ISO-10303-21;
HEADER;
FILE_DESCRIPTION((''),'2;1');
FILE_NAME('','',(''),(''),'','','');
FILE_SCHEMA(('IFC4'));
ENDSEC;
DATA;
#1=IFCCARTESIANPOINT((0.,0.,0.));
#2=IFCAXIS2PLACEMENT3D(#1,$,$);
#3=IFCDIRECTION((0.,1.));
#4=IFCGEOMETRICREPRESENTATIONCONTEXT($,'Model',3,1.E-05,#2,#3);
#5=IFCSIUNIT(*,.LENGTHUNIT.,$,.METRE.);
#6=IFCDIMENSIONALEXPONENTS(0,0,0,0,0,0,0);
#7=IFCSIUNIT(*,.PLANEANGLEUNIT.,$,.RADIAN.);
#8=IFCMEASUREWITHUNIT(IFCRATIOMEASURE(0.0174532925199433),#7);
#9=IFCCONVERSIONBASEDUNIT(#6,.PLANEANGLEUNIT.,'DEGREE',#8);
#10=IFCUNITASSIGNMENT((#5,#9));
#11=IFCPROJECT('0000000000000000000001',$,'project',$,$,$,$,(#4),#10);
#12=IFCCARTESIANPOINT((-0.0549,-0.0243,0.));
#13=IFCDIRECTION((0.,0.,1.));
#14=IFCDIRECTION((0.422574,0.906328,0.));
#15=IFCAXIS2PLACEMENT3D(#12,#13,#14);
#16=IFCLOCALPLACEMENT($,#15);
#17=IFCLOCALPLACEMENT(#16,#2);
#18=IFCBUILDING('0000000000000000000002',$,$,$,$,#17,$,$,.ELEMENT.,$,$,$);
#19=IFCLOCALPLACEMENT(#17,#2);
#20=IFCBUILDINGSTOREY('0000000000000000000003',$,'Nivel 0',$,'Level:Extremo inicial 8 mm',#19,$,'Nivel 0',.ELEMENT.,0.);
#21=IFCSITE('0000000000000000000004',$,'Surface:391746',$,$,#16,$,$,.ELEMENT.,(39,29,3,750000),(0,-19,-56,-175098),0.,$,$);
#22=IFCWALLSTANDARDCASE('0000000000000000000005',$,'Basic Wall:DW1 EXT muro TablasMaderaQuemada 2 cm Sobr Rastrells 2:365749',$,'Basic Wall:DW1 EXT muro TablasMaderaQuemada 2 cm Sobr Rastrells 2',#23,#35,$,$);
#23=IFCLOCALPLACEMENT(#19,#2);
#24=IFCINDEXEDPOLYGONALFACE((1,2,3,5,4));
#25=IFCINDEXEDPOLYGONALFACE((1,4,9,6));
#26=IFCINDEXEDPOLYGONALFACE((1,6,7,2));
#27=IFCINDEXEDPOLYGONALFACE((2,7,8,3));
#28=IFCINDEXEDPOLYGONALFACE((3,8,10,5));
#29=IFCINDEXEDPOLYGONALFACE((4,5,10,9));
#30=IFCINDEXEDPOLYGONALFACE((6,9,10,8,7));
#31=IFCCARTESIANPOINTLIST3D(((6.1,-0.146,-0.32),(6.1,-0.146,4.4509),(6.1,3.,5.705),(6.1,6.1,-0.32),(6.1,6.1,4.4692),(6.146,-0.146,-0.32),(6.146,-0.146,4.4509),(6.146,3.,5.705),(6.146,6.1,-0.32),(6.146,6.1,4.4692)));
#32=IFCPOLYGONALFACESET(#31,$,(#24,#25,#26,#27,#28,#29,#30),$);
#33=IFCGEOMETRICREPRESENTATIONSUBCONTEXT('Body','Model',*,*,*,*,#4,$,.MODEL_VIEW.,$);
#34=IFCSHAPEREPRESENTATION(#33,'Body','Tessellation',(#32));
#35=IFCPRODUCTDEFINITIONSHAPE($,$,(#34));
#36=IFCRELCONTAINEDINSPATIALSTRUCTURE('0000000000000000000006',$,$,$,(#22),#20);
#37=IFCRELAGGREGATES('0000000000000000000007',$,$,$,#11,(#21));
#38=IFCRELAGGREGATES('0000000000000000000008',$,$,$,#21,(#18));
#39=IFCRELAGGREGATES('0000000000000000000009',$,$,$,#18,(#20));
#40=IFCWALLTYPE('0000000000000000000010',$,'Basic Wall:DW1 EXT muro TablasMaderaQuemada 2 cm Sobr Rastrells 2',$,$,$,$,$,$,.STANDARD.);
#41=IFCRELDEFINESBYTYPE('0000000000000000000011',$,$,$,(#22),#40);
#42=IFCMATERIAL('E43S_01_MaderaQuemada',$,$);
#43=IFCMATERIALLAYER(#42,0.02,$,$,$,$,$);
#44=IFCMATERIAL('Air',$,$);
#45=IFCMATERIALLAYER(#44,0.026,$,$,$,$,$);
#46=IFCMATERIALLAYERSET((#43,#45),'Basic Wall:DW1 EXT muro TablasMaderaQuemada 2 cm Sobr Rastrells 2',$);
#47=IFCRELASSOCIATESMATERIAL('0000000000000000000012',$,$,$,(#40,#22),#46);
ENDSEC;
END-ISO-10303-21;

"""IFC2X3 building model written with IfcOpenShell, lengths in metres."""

from ifc_helpers import new_model, entity, si_unit, converted_unit, direction, frame, frame_2d, origin, place, context, subcontext, project, spatial, polyline, rectangle, extrude, clip, bounded_halfspace, material, layer, layer_set, layer_usage, type_object, element, save


model = new_model("IFC2X3")

# Units and contexts
model_context = context("Model", 3, precision=1e-05, world=origin(), true_north=direction((0.0, 1.0)))
body_context = subcontext(model_context, "Body", "Model", "MODEL_VIEW")
ifc_project = project(units=[si_unit("LENGTHUNIT", "METRE"), converted_unit("PLANEANGLEUNIT", "DEGREE", entity("IfcRatioMeasure", 0.0174532925199433), si_unit("PLANEANGLEUNIT", "RADIAN"), dimensions=[0, 0, 0, 0, 0, 0, 0])], contexts=[model_context])

# Site, building, storey
site_placement = place(None, frame((-0.0549, -0.0243, 0.0), z_axis=(0.0, 0.0, 1.0), x_axis=(0.422574, 0.906328, 0.0)))
site = spatial("IfcSite", under=ifc_project, at=site_placement, Name="Surface:391746", CompositionType="ELEMENT", RefLatitude=(39, 29, 3, 750000), RefLongitude=(0, -19, -56, -175098), RefElevation=0.0)
building_placement = place(site_placement, origin())
building = spatial("IfcBuilding", under=site, at=building_placement, CompositionType="ELEMENT")
storey_placement = place(building_placement, origin())
storey = spatial("IfcBuildingStorey", under=building, at=storey_placement, Name="Nivel 0", ObjectType="Level:Extremo inicial 8 mm", LongName="Nivel 0", CompositionType="ELEMENT", Elevation=0.0)

# Wall
ifc_material_1 = material(Name="E43S_01_MaderaQuemada")
ifc_layer_1 = layer(ifc_material_1, 0.02)
ifc_material_2 = material(Name="Air")
ifc_layer_2 = layer(ifc_material_2, 0.026)
ifc_layer_set_1 = layer_set([ifc_layer_1, ifc_layer_2], Name="Basic Wall:DW1 EXT muro TablasMaderaQuemada 2 cm Sobr Rastrells 2")
ifc_layer_usage_1 = layer_usage(ifc_layer_set_1, "AXIS2", "NEGATIVE", 0.023)
wall_type_1 = type_object("IfcWallType", Name="Basic Wall:DW1 EXT muro TablasMaderaQuemada 2 cm Sobr Rastrells 2", PredefinedType="STANDARD", material=ifc_layer_set_1)
wall_1_placement = place(storey_placement, frame((6.123, 6.1, -0.32), z_axis=(0.0, 0.0, 1.0), x_axis=(0.0, -1.0, 0.0)))
element("IfcWallStandardCase", 1, at=wall_1_placement, inside=storey, type_object=wall_type_1, material=ifc_layer_usage_1, Name="Basic Wall:DW1 EXT muro TablasMaderaQuemada 2 cm Sobr Rastrells 2:365749", ObjectType="Basic Wall:DW1 EXT muro TablasMaderaQuemada 2 cm Sobr Rastrells 2", context=body_context, shape_type="Clipping", body=[
    clip(clip(extrude(rectangle(XDim=6.246, YDim=0.046, at=frame_2d((3.123, 0.0), x_axis=(-1.0, 0.0))), origin(), (0.0, 0.0, 1.0), 6.025), bounded_halfspace(frame((0.0, -0.023, 4.7892), z_axis=(-0.370288, 0.0, 0.928917), x_axis=(0.0, -1.0, 0.0)), False, frame((0.0, -0.023, 4.7892)), polyline([(0.0, 0.0), (3.1, 0.0), (3.1, 0.046), (0.0, 0.046), (0.0, 0.0)]))), bounded_halfspace(frame((3.1, -0.023, 6.025), z_axis=(0.370288, 0.0, 0.928917), x_axis=(0.0, 1.0, 0.0)), False, frame((3.1, -0.023, 6.025)), polyline([(0.0, 0.0), (3.1, 0.0), (3.146, 0.0), (3.146, 0.046), (0.0, 0.046), (0.0, 0.0)]))),
])

save(model, "model.ifc")
